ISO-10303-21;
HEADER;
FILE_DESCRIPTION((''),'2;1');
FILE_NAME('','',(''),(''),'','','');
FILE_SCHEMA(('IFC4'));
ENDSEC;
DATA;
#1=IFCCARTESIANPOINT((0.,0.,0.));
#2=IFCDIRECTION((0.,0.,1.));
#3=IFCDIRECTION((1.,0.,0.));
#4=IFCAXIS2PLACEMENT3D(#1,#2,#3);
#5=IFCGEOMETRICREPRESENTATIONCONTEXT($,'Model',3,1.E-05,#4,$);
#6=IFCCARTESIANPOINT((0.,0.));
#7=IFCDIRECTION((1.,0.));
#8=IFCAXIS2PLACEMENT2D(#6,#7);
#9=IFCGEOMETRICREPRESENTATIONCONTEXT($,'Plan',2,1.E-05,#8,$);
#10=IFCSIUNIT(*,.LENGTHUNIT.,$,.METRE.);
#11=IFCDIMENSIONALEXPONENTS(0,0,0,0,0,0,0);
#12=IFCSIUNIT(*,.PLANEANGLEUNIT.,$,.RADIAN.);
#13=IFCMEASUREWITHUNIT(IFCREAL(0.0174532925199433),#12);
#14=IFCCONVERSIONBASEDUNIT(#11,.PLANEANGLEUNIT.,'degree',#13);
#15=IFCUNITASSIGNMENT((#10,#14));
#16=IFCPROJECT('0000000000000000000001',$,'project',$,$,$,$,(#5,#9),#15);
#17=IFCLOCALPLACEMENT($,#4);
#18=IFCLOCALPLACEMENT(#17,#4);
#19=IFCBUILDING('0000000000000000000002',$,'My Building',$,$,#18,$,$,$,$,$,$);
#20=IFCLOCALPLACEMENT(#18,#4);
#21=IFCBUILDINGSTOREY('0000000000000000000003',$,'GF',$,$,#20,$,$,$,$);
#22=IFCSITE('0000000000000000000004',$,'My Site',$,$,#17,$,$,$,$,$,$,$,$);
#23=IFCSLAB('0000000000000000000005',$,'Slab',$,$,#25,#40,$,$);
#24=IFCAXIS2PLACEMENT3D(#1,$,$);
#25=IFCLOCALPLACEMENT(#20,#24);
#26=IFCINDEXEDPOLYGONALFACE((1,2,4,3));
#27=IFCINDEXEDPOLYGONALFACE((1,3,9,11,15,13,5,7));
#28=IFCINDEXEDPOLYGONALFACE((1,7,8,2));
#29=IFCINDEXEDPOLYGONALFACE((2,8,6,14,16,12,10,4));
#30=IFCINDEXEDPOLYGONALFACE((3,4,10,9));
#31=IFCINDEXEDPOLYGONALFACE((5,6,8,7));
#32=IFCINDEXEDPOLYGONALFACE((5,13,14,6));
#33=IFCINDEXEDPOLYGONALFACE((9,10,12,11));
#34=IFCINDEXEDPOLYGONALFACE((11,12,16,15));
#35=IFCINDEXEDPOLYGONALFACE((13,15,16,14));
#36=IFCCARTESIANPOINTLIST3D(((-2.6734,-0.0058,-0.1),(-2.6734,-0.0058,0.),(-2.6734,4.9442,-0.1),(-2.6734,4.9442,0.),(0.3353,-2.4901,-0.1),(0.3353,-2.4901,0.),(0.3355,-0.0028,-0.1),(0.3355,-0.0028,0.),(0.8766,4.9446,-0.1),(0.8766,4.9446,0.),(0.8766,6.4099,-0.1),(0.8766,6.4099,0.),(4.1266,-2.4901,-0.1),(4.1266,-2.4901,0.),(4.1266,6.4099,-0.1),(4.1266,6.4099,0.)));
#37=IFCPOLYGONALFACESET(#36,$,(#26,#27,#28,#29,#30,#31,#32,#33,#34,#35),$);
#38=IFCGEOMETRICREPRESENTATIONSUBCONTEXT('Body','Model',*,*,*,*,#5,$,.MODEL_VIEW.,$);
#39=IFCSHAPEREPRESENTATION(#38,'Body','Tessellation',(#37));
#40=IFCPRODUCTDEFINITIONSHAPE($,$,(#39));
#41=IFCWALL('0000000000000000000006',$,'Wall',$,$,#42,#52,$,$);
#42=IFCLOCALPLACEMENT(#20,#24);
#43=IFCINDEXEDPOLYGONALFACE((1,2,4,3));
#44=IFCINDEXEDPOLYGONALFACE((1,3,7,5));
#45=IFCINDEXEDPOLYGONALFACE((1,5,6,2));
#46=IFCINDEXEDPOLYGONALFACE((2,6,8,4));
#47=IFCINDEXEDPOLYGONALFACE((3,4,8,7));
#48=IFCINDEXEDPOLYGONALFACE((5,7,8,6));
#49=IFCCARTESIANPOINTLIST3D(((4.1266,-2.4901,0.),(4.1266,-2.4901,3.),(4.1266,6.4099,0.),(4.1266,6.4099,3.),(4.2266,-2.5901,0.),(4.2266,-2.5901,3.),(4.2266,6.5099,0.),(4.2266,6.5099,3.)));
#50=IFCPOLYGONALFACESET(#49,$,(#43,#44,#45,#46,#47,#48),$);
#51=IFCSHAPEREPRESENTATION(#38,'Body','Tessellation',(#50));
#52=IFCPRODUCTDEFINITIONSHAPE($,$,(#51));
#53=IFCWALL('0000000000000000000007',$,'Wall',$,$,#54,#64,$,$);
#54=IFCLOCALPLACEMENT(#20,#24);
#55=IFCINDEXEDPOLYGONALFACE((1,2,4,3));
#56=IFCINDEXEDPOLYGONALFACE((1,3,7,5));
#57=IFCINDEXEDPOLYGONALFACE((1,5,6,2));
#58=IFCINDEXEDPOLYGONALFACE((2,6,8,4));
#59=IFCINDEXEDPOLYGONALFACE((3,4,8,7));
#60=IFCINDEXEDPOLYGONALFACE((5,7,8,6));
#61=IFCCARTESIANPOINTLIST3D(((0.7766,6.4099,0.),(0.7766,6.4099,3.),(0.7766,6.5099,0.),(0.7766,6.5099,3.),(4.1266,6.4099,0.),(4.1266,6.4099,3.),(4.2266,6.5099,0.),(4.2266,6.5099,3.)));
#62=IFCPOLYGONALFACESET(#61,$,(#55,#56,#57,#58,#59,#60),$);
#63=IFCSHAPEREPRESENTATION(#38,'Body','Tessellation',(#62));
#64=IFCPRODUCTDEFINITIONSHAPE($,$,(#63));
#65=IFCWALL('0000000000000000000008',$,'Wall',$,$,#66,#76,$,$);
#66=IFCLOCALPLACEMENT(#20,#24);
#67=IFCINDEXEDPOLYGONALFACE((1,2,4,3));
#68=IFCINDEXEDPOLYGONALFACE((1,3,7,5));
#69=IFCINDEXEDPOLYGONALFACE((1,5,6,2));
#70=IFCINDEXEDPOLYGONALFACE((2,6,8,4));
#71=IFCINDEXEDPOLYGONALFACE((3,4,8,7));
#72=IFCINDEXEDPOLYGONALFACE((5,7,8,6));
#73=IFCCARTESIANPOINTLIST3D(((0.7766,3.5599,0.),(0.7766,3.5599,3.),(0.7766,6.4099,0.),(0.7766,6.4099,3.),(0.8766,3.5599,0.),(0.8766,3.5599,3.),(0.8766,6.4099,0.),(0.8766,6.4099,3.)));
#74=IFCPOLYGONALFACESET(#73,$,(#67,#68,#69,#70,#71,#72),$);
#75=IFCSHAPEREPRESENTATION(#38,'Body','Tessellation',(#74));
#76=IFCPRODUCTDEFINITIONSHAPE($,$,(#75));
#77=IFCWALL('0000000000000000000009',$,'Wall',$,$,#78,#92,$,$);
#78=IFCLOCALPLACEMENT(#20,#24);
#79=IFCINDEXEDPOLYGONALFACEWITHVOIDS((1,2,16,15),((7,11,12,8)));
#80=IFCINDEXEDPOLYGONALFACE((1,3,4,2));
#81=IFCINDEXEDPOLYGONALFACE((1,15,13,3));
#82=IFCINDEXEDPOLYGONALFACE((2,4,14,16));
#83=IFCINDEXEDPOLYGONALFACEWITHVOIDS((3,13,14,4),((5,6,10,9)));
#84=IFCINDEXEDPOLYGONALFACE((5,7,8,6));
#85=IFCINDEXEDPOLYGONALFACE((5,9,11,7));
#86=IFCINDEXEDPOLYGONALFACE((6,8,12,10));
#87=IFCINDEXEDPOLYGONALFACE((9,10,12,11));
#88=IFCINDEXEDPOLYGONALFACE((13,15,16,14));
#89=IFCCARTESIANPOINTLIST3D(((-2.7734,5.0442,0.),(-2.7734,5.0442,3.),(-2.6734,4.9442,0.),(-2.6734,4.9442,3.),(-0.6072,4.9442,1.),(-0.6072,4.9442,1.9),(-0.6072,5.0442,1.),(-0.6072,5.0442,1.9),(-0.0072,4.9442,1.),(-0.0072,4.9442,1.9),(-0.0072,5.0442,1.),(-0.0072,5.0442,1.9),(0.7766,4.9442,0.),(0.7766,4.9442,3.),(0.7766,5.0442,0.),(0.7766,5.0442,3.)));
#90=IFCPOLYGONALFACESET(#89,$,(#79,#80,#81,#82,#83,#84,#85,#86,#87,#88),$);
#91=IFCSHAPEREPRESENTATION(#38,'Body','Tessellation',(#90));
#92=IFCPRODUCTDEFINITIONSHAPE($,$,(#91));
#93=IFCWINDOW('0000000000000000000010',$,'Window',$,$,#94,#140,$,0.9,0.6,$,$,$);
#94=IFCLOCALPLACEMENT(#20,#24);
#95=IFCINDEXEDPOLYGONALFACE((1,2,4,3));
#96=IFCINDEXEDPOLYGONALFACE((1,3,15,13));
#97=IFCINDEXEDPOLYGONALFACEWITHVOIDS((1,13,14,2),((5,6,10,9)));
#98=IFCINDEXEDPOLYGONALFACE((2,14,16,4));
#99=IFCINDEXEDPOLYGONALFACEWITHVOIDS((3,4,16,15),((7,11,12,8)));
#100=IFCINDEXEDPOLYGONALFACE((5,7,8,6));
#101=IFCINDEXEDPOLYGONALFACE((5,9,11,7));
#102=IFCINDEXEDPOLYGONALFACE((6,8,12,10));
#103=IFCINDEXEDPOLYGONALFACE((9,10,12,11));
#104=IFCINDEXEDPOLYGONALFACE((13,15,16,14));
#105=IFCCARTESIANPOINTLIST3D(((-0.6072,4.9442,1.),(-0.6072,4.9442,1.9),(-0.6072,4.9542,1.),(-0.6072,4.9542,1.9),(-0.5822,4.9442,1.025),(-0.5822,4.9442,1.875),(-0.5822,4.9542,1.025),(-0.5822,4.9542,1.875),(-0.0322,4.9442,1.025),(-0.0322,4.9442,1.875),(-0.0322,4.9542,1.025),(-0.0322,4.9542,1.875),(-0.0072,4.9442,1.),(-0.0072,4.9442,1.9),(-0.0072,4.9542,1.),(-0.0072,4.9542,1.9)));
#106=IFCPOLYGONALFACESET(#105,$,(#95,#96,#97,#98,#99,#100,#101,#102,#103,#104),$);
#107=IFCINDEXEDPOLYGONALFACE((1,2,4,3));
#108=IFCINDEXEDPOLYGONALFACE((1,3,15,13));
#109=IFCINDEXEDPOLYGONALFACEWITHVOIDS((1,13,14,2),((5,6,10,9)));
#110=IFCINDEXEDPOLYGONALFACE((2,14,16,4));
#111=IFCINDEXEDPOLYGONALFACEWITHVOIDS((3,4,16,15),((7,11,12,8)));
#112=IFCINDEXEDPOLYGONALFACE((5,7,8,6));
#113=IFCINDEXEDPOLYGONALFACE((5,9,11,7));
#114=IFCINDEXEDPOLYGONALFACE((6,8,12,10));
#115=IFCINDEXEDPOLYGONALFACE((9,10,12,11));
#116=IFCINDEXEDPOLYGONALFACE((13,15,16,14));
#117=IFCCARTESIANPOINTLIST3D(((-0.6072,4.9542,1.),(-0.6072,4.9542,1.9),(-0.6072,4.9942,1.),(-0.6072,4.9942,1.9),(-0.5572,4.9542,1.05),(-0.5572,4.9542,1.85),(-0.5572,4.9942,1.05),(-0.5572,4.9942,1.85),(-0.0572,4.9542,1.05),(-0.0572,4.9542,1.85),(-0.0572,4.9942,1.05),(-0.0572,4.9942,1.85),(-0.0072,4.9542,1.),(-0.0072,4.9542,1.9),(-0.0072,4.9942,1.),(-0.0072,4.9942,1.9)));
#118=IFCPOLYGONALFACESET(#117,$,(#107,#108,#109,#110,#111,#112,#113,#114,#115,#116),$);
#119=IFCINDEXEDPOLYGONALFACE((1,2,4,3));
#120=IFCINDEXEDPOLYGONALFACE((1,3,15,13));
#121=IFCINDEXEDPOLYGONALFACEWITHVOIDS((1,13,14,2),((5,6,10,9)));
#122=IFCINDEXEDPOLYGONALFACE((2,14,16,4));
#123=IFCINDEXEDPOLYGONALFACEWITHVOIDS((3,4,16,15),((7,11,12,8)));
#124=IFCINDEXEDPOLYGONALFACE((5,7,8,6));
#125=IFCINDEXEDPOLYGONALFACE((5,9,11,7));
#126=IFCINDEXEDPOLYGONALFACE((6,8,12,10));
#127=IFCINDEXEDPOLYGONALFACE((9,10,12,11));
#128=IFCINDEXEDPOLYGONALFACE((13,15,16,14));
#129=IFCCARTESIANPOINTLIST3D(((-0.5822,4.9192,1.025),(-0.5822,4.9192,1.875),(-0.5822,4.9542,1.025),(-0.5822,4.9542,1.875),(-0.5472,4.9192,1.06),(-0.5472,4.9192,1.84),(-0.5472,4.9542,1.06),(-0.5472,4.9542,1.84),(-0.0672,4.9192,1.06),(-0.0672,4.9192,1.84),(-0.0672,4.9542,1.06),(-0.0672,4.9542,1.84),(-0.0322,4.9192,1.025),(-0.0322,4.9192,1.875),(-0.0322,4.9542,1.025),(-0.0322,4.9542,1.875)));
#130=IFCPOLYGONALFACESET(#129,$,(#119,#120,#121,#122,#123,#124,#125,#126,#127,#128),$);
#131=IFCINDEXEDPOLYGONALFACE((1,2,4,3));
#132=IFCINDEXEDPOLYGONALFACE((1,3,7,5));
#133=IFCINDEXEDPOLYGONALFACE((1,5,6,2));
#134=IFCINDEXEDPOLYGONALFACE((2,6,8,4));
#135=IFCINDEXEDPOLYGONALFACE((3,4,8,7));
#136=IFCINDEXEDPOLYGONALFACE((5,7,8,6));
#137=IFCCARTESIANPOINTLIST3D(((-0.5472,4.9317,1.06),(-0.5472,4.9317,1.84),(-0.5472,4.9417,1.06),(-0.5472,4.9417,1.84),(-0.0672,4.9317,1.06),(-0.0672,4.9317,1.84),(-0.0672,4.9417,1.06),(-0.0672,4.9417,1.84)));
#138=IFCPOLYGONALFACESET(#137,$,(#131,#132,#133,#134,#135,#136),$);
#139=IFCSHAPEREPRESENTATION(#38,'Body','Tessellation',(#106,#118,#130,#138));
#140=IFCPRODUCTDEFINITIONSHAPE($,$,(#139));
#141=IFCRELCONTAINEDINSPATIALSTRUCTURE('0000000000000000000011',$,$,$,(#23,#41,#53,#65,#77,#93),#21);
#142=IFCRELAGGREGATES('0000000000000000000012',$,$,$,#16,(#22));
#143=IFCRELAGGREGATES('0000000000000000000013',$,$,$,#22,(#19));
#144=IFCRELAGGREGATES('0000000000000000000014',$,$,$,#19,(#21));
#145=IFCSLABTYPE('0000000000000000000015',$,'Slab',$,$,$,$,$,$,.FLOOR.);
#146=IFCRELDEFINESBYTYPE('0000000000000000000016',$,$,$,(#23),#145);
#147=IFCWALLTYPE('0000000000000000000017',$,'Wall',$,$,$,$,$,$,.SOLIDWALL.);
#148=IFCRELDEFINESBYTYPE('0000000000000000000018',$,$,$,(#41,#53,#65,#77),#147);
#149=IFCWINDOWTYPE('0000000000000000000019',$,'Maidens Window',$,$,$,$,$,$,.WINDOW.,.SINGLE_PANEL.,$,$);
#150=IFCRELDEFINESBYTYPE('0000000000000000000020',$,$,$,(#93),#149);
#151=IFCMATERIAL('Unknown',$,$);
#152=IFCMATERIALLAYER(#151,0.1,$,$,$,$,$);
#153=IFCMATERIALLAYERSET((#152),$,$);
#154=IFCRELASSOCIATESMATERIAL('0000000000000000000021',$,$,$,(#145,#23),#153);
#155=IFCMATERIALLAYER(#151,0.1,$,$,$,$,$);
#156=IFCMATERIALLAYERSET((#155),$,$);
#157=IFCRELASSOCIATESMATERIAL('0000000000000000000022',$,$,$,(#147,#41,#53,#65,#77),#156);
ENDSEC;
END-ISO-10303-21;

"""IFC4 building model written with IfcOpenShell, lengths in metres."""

from ifc_helpers import new_model, entity, si_unit, converted_unit, frame, origin_with_axes, origin_2d_with_axis, place, context, subcontext, project, spatial, line, indexed_curve, outline, extrude, shape, source, transform, mapped, material, layer, layer_set, layer_usage, type_object, type_shapes, element, fill, save


model = new_model("IFC4")

# Units and contexts
model_context = context("Model", 3, precision=1e-05, world=origin_with_axes())
plan_context = context("Plan", 2, precision=1e-05, world=origin_2d_with_axis())
body_context_1 = subcontext(model_context, "Body", "Model", "MODEL_VIEW")
body_context_2 = subcontext(plan_context, "Body", "Plan", "PLAN_VIEW")
ifc_project = project(units=[si_unit("LENGTHUNIT", "METRE"), converted_unit("PLANEANGLEUNIT", "degree", entity("IfcReal", 0.0174532925199433), si_unit("PLANEANGLEUNIT", "RADIAN"), dimensions=[0, 0, 0, 0, 0, 0, 0])], contexts=[model_context, plan_context])

# Site, building, storey
site_placement = place(None, origin_with_axes())
site = spatial("IfcSite", under=ifc_project, at=site_placement, Name="My Site")
building_placement = place(site_placement, origin_with_axes())
building = spatial("IfcBuilding", under=site, at=building_placement, Name="My Building")
storey_placement = place(building_placement, origin_with_axes())
storey = spatial("IfcBuildingStorey", under=building, at=storey_placement, Name="GF")

# Slab
ifc_material = material(Name="Unknown")
ifc_layer_1 = layer(ifc_material, 0.1)
ifc_layer_set_1 = layer_set([ifc_layer_1])
ifc_layer_usage_1 = layer_usage(ifc_layer_set_1, "AXIS3", "POSITIVE", -0.1)
slab_type = type_object("IfcSlabType", Name="Slab", PredefinedType="FLOOR", material=ifc_layer_set_1)
slab_placement = place(storey_placement, frame((-2.6734, 4.9442, 0.0), z_axis=(0.0, 0.0, 1.0), x_axis=(1.0, 0.0, 0.0)))
element("IfcSlab", 1, at=slab_placement, inside=storey, type_object=slab_type, material=ifc_layer_usage_1, Name="Slab", context=body_context_1, shape_type="SweptSolid", body=[
    extrude(outline(indexed_curve([(0.0, 0.0), (3.55, 0.0004), (3.55, 1.4657), (6.8, 1.4657), (6.8, -7.4343), (3.0087, -7.4343), (3.0089, -4.947), (0.0, -4.95), (0.0, 0.0)])), frame((0.0, 0.0, -0.1), z_axis=(0.0, 0.0, 1.0), x_axis=(1.0, 0.0, 0.0)), (0.0, 0.0, 1.0), 0.1),
])

# Shared definitions
ifc_layer_2 = layer(ifc_material, 0.1)
ifc_layer_set_2 = layer_set([ifc_layer_2])
wall_type = type_object("IfcWallType", Name="Wall", PredefinedType="SOLIDWALL", material=ifc_layer_set_2)

# Walls
ifc_layer_usage_2 = layer_usage(ifc_layer_set_2, "AXIS2", "POSITIVE", 0.0)
wall_1_placement = place(storey_placement, frame((4.2266, -2.5901, 0.0), z_axis=(0.0, 0.0, 1.0), x_axis=(0.0, 1.0, 0.0)))
element("IfcWall", 2, at=wall_1_placement, inside=storey, type_object=wall_type, material=ifc_layer_usage_2, Name="Wall", context=body_context_1, shape_type="SweptSolid", body=[
    extrude(outline(indexed_curve([(0.0, 0.0), (0.1, 0.1), (9.0, 0.1), (9.1, 0.0)], segments=[line(1, 2, 3, 4, 1)])), origin_with_axes(), (0.0, 0.0, 1.0), 3.0),
])
ifc_layer_usage_3 = layer_usage(ifc_layer_set_2, "AXIS2", "POSITIVE", 0.0)
wall_2_placement = place(storey_placement, frame((4.2266, 6.5099, 0.0), z_axis=(0.0, 0.0, 1.0), x_axis=(-1.0, 0.0, 0.0)))
element("IfcWall", 3, at=wall_2_placement, inside=storey, type_object=wall_type, material=ifc_layer_usage_3, Name="Wall", context=body_context_1, shape_type="SweptSolid", body=[
    extrude(outline(indexed_curve([(0.0, 0.0), (0.1, 0.1), (3.45, 0.1), (3.45, 0.0)], segments=[line(1, 2, 3, 4, 1)])), origin_with_axes(), (0.0, 0.0, 1.0), 3.0),
])
ifc_layer_usage_4 = layer_usage(ifc_layer_set_2, "AXIS2", "POSITIVE", 0.0)
wall_3_placement = place(storey_placement, frame((0.7766, 6.4099, 0.0), z_axis=(0.0, 0.0, 1.0), x_axis=(0.0, -1.0, 0.0)))
element("IfcWall", 4, at=wall_3_placement, inside=storey, type_object=wall_type, material=ifc_layer_usage_4, Name="Wall", context=body_context_1, shape_type="SweptSolid", body=[
    extrude(outline(indexed_curve([(0.0, 0.0), (0.0, 0.1), (2.85, 0.1), (2.85, 0.0)], segments=[line(1, 2, 3, 4, 1)])), origin_with_axes(), (0.0, 0.0, 1.0), 3.0),
])

# Wall, opening, window
ifc_layer_usage_5 = layer_usage(ifc_layer_set_2, "AXIS2", "POSITIVE", 0.0)
wall_4_placement = place(storey_placement, frame((0.7766, 5.0442, 0.0), z_axis=(0.0, 0.0, 1.0), x_axis=(-1.0, 0.0, 0.0)))
wall_4 = element("IfcWall", 5, at=wall_4_placement, inside=storey, type_object=wall_type, material=ifc_layer_usage_5, Name="Wall", context=body_context_1, shape_type="SweptSolid", body=[
    extrude(outline(indexed_curve([(0.0, 0.0), (0.0, 0.1), (3.45, 0.1), (3.55, 0.0)], segments=[line(1, 2, 3, 4, 1)])), origin_with_axes(), (0.0, 0.0, 1.0), 3.0),
])
shared_shape_1 = source(origin_with_axes(), body_context_1, "Body", "SweptSolid", [
    extrude(outline(indexed_curve([(0.0, 0.0), (0.6, 0.0), (0.6, 0.9), (0.0, 0.9)], segments=[line(1, 2, 3, 4, 1)])), frame((0.0, -0.6, 0.0), z_axis=(0.0, -1.0, 0.0), x_axis=(1.0, 0.0, 0.0)), (0.0, 0.0, -1.0), 1.2),
])
opening_1_placement = place(wall_4_placement, frame((0.7838, 0.0, 1.0), z_axis=(0.0, 0.0, 1.0), x_axis=(1.0, 0.0, 0.0)))
opening_1 = element("IfcOpeningElement", 6, at=opening_1_placement, cuts=wall_4, PredefinedType="OPENING", context=body_context_1, shape_type="MappedRepresentation", body=[
    mapped(shared_shape_1, transform((0.0, 0.0, 0.0), x_axis=(1.0, 0.0, 0.0), y_axis=(0.0, 1.0, 0.0), z_axis=(0.0, 0.0, 1.0), scale=1.0)),
])
window_type_1 = type_object("IfcWindowType", Name="Maidens Window", PartitioningType="SINGLE_PANEL", PredefinedType="WINDOW")
shared_shape_2 = source(origin_with_axes(), body_context_1, "Body", "SweptSolid", [
    extrude(outline(indexed_curve([(0.0, 0.0), (0.6, 0.0), (0.6, 0.9), (0.0, 0.9)], segments=[line(1, 2, 3, 4, 1)]), holes=[indexed_curve([(0.025, 0.025), (0.575, 0.025), (0.575, 0.875), (0.025, 0.875)], segments=[line(1, 2, 3, 4, 1)])]), frame((0.0, 0.09, 0.0), z_axis=(0.0, -1.0, 0.0), x_axis=(1.0, 0.0, 0.0)), (0.0, 0.0, -1.0), 0.01),
    extrude(outline(indexed_curve([(0.0, 0.0), (0.6, 0.0), (0.6, 0.9), (0.0, 0.9)], segments=[line(1, 2, 3, 4, 1)]), holes=[indexed_curve([(0.05, 0.05), (0.55, 0.05), (0.55, 0.85), (0.05, 0.85)], segments=[line(1, 2, 3, 4, 1)])]), frame((0.0, 0.05, 0.0), z_axis=(0.0, -1.0, 0.0), x_axis=(1.0, 0.0, 0.0)), (0.0, 0.0, -1.0), 0.04),
    extrude(outline(indexed_curve([(0.0, 0.0), (0.55, 0.0), (0.55, 0.85), (0.0, 0.85)], segments=[line(1, 2, 3, 4, 1)]), holes=[indexed_curve([(0.035, 0.035), (0.515, 0.035), (0.515, 0.815), (0.035, 0.815)], segments=[line(1, 2, 3, 4, 1)])]), frame((0.025, 0.09, 0.025), z_axis=(0.0, -1.0, 0.0), x_axis=(1.0, 0.0, 0.0)), (0.0, 0.0, -1.0), 0.035),
    extrude(outline(indexed_curve([(0.035, 0.035), (0.515, 0.035), (0.515, 0.815), (0.035, 0.815)], segments=[line(1, 2, 3, 4, 1)])), frame((0.025, 0.1025, 0.025), z_axis=(0.0, -1.0, 0.0), x_axis=(1.0, 0.0, 0.0)), (0.0, 0.0, -1.0), 0.01),
])
shared_shape_3 = source(origin_with_axes(), body_context_2, "Body", "Curve2D", [
    entity("IfcIndexedPolyCurve", entity("IfcCartesianPointList2D", [[0.05, 0.05], [0.55, 0.05]])),
    entity("IfcIndexedPolyCurve", entity("IfcCartesianPointList2D", [[0.0, 0.1], [0.025, 0.1], [0.025, 0.09], [0.05, 0.09], [0.05, 0.05], [0.0, 0.05]]), [entity("IfcLineIndex", [1, 2, 3, 4, 5, 6, 1])]),
    entity("IfcIndexedPolyCurve", entity("IfcCartesianPointList2D", [[0.6, 0.1], [0.575, 0.1], [0.575, 0.09], [0.55, 0.09], [0.55, 0.05], [0.6, 0.05]]), [entity("IfcLineIndex", [1, 2, 3, 4, 5, 6, 1])]),
    entity("IfcIndexedPolyCurve", entity("IfcCartesianPointList2D", [[0.025, 0.09], [0.06, 0.09], [0.06, 0.125], [0.025, 0.125]]), [entity("IfcLineIndex", [1, 2, 3, 4, 1])]),
    entity("IfcIndexedPolyCurve", entity("IfcCartesianPointList2D", [[0.575, 0.09], [0.54, 0.09], [0.54, 0.125], [0.575, 0.125]]), [entity("IfcLineIndex", [1, 2, 3, 4, 1])]),
    entity("IfcIndexedPolyCurve", entity("IfcCartesianPointList2D", [[0.06, 0.09], [0.54, 0.09]])),
    entity("IfcIndexedPolyCurve", entity("IfcCartesianPointList2D", [[0.06, 0.125], [0.54, 0.125]])),
    entity("IfcIndexedPolyCurve", entity("IfcCartesianPointList2D", [[0.06, 0.1075], [0.54, 0.1075]])),
])
type_shapes(window_type_1, [shared_shape_2, shared_shape_3])
window_1_placement = place(opening_1_placement, frame((0.0, 0.0, 0.0), z_axis=(0.0, 0.0, 1.0), x_axis=(1.0, 0.0, 0.0)))
window_1 = element("IfcWindow", 7, at=window_1_placement, inside=storey, type_object=window_type_1, Name="Window", OverallHeight=0.9, OverallWidth=0.6, shapes=[
    shape(body_context_1, "Body", "MappedRepresentation", [mapped(shared_shape_2, transform((0.0, 0.0, 0.0), x_axis=(1.0, 0.0, 0.0), y_axis=(0.0, 1.0, 0.0), z_axis=(0.0, 0.0, 1.0), scale=1.0))]),
    shape(body_context_2, "Body", "MappedRepresentation", [mapped(shared_shape_3, transform((0.0, 0.0, 0.0), x_axis=(1.0, 0.0, 0.0), y_axis=(0.0, 1.0, 0.0), z_axis=(0.0, 0.0, 1.0), scale=1.0))]),
])
fill(opening_1, window_1)

save(model, "model.ifc")
